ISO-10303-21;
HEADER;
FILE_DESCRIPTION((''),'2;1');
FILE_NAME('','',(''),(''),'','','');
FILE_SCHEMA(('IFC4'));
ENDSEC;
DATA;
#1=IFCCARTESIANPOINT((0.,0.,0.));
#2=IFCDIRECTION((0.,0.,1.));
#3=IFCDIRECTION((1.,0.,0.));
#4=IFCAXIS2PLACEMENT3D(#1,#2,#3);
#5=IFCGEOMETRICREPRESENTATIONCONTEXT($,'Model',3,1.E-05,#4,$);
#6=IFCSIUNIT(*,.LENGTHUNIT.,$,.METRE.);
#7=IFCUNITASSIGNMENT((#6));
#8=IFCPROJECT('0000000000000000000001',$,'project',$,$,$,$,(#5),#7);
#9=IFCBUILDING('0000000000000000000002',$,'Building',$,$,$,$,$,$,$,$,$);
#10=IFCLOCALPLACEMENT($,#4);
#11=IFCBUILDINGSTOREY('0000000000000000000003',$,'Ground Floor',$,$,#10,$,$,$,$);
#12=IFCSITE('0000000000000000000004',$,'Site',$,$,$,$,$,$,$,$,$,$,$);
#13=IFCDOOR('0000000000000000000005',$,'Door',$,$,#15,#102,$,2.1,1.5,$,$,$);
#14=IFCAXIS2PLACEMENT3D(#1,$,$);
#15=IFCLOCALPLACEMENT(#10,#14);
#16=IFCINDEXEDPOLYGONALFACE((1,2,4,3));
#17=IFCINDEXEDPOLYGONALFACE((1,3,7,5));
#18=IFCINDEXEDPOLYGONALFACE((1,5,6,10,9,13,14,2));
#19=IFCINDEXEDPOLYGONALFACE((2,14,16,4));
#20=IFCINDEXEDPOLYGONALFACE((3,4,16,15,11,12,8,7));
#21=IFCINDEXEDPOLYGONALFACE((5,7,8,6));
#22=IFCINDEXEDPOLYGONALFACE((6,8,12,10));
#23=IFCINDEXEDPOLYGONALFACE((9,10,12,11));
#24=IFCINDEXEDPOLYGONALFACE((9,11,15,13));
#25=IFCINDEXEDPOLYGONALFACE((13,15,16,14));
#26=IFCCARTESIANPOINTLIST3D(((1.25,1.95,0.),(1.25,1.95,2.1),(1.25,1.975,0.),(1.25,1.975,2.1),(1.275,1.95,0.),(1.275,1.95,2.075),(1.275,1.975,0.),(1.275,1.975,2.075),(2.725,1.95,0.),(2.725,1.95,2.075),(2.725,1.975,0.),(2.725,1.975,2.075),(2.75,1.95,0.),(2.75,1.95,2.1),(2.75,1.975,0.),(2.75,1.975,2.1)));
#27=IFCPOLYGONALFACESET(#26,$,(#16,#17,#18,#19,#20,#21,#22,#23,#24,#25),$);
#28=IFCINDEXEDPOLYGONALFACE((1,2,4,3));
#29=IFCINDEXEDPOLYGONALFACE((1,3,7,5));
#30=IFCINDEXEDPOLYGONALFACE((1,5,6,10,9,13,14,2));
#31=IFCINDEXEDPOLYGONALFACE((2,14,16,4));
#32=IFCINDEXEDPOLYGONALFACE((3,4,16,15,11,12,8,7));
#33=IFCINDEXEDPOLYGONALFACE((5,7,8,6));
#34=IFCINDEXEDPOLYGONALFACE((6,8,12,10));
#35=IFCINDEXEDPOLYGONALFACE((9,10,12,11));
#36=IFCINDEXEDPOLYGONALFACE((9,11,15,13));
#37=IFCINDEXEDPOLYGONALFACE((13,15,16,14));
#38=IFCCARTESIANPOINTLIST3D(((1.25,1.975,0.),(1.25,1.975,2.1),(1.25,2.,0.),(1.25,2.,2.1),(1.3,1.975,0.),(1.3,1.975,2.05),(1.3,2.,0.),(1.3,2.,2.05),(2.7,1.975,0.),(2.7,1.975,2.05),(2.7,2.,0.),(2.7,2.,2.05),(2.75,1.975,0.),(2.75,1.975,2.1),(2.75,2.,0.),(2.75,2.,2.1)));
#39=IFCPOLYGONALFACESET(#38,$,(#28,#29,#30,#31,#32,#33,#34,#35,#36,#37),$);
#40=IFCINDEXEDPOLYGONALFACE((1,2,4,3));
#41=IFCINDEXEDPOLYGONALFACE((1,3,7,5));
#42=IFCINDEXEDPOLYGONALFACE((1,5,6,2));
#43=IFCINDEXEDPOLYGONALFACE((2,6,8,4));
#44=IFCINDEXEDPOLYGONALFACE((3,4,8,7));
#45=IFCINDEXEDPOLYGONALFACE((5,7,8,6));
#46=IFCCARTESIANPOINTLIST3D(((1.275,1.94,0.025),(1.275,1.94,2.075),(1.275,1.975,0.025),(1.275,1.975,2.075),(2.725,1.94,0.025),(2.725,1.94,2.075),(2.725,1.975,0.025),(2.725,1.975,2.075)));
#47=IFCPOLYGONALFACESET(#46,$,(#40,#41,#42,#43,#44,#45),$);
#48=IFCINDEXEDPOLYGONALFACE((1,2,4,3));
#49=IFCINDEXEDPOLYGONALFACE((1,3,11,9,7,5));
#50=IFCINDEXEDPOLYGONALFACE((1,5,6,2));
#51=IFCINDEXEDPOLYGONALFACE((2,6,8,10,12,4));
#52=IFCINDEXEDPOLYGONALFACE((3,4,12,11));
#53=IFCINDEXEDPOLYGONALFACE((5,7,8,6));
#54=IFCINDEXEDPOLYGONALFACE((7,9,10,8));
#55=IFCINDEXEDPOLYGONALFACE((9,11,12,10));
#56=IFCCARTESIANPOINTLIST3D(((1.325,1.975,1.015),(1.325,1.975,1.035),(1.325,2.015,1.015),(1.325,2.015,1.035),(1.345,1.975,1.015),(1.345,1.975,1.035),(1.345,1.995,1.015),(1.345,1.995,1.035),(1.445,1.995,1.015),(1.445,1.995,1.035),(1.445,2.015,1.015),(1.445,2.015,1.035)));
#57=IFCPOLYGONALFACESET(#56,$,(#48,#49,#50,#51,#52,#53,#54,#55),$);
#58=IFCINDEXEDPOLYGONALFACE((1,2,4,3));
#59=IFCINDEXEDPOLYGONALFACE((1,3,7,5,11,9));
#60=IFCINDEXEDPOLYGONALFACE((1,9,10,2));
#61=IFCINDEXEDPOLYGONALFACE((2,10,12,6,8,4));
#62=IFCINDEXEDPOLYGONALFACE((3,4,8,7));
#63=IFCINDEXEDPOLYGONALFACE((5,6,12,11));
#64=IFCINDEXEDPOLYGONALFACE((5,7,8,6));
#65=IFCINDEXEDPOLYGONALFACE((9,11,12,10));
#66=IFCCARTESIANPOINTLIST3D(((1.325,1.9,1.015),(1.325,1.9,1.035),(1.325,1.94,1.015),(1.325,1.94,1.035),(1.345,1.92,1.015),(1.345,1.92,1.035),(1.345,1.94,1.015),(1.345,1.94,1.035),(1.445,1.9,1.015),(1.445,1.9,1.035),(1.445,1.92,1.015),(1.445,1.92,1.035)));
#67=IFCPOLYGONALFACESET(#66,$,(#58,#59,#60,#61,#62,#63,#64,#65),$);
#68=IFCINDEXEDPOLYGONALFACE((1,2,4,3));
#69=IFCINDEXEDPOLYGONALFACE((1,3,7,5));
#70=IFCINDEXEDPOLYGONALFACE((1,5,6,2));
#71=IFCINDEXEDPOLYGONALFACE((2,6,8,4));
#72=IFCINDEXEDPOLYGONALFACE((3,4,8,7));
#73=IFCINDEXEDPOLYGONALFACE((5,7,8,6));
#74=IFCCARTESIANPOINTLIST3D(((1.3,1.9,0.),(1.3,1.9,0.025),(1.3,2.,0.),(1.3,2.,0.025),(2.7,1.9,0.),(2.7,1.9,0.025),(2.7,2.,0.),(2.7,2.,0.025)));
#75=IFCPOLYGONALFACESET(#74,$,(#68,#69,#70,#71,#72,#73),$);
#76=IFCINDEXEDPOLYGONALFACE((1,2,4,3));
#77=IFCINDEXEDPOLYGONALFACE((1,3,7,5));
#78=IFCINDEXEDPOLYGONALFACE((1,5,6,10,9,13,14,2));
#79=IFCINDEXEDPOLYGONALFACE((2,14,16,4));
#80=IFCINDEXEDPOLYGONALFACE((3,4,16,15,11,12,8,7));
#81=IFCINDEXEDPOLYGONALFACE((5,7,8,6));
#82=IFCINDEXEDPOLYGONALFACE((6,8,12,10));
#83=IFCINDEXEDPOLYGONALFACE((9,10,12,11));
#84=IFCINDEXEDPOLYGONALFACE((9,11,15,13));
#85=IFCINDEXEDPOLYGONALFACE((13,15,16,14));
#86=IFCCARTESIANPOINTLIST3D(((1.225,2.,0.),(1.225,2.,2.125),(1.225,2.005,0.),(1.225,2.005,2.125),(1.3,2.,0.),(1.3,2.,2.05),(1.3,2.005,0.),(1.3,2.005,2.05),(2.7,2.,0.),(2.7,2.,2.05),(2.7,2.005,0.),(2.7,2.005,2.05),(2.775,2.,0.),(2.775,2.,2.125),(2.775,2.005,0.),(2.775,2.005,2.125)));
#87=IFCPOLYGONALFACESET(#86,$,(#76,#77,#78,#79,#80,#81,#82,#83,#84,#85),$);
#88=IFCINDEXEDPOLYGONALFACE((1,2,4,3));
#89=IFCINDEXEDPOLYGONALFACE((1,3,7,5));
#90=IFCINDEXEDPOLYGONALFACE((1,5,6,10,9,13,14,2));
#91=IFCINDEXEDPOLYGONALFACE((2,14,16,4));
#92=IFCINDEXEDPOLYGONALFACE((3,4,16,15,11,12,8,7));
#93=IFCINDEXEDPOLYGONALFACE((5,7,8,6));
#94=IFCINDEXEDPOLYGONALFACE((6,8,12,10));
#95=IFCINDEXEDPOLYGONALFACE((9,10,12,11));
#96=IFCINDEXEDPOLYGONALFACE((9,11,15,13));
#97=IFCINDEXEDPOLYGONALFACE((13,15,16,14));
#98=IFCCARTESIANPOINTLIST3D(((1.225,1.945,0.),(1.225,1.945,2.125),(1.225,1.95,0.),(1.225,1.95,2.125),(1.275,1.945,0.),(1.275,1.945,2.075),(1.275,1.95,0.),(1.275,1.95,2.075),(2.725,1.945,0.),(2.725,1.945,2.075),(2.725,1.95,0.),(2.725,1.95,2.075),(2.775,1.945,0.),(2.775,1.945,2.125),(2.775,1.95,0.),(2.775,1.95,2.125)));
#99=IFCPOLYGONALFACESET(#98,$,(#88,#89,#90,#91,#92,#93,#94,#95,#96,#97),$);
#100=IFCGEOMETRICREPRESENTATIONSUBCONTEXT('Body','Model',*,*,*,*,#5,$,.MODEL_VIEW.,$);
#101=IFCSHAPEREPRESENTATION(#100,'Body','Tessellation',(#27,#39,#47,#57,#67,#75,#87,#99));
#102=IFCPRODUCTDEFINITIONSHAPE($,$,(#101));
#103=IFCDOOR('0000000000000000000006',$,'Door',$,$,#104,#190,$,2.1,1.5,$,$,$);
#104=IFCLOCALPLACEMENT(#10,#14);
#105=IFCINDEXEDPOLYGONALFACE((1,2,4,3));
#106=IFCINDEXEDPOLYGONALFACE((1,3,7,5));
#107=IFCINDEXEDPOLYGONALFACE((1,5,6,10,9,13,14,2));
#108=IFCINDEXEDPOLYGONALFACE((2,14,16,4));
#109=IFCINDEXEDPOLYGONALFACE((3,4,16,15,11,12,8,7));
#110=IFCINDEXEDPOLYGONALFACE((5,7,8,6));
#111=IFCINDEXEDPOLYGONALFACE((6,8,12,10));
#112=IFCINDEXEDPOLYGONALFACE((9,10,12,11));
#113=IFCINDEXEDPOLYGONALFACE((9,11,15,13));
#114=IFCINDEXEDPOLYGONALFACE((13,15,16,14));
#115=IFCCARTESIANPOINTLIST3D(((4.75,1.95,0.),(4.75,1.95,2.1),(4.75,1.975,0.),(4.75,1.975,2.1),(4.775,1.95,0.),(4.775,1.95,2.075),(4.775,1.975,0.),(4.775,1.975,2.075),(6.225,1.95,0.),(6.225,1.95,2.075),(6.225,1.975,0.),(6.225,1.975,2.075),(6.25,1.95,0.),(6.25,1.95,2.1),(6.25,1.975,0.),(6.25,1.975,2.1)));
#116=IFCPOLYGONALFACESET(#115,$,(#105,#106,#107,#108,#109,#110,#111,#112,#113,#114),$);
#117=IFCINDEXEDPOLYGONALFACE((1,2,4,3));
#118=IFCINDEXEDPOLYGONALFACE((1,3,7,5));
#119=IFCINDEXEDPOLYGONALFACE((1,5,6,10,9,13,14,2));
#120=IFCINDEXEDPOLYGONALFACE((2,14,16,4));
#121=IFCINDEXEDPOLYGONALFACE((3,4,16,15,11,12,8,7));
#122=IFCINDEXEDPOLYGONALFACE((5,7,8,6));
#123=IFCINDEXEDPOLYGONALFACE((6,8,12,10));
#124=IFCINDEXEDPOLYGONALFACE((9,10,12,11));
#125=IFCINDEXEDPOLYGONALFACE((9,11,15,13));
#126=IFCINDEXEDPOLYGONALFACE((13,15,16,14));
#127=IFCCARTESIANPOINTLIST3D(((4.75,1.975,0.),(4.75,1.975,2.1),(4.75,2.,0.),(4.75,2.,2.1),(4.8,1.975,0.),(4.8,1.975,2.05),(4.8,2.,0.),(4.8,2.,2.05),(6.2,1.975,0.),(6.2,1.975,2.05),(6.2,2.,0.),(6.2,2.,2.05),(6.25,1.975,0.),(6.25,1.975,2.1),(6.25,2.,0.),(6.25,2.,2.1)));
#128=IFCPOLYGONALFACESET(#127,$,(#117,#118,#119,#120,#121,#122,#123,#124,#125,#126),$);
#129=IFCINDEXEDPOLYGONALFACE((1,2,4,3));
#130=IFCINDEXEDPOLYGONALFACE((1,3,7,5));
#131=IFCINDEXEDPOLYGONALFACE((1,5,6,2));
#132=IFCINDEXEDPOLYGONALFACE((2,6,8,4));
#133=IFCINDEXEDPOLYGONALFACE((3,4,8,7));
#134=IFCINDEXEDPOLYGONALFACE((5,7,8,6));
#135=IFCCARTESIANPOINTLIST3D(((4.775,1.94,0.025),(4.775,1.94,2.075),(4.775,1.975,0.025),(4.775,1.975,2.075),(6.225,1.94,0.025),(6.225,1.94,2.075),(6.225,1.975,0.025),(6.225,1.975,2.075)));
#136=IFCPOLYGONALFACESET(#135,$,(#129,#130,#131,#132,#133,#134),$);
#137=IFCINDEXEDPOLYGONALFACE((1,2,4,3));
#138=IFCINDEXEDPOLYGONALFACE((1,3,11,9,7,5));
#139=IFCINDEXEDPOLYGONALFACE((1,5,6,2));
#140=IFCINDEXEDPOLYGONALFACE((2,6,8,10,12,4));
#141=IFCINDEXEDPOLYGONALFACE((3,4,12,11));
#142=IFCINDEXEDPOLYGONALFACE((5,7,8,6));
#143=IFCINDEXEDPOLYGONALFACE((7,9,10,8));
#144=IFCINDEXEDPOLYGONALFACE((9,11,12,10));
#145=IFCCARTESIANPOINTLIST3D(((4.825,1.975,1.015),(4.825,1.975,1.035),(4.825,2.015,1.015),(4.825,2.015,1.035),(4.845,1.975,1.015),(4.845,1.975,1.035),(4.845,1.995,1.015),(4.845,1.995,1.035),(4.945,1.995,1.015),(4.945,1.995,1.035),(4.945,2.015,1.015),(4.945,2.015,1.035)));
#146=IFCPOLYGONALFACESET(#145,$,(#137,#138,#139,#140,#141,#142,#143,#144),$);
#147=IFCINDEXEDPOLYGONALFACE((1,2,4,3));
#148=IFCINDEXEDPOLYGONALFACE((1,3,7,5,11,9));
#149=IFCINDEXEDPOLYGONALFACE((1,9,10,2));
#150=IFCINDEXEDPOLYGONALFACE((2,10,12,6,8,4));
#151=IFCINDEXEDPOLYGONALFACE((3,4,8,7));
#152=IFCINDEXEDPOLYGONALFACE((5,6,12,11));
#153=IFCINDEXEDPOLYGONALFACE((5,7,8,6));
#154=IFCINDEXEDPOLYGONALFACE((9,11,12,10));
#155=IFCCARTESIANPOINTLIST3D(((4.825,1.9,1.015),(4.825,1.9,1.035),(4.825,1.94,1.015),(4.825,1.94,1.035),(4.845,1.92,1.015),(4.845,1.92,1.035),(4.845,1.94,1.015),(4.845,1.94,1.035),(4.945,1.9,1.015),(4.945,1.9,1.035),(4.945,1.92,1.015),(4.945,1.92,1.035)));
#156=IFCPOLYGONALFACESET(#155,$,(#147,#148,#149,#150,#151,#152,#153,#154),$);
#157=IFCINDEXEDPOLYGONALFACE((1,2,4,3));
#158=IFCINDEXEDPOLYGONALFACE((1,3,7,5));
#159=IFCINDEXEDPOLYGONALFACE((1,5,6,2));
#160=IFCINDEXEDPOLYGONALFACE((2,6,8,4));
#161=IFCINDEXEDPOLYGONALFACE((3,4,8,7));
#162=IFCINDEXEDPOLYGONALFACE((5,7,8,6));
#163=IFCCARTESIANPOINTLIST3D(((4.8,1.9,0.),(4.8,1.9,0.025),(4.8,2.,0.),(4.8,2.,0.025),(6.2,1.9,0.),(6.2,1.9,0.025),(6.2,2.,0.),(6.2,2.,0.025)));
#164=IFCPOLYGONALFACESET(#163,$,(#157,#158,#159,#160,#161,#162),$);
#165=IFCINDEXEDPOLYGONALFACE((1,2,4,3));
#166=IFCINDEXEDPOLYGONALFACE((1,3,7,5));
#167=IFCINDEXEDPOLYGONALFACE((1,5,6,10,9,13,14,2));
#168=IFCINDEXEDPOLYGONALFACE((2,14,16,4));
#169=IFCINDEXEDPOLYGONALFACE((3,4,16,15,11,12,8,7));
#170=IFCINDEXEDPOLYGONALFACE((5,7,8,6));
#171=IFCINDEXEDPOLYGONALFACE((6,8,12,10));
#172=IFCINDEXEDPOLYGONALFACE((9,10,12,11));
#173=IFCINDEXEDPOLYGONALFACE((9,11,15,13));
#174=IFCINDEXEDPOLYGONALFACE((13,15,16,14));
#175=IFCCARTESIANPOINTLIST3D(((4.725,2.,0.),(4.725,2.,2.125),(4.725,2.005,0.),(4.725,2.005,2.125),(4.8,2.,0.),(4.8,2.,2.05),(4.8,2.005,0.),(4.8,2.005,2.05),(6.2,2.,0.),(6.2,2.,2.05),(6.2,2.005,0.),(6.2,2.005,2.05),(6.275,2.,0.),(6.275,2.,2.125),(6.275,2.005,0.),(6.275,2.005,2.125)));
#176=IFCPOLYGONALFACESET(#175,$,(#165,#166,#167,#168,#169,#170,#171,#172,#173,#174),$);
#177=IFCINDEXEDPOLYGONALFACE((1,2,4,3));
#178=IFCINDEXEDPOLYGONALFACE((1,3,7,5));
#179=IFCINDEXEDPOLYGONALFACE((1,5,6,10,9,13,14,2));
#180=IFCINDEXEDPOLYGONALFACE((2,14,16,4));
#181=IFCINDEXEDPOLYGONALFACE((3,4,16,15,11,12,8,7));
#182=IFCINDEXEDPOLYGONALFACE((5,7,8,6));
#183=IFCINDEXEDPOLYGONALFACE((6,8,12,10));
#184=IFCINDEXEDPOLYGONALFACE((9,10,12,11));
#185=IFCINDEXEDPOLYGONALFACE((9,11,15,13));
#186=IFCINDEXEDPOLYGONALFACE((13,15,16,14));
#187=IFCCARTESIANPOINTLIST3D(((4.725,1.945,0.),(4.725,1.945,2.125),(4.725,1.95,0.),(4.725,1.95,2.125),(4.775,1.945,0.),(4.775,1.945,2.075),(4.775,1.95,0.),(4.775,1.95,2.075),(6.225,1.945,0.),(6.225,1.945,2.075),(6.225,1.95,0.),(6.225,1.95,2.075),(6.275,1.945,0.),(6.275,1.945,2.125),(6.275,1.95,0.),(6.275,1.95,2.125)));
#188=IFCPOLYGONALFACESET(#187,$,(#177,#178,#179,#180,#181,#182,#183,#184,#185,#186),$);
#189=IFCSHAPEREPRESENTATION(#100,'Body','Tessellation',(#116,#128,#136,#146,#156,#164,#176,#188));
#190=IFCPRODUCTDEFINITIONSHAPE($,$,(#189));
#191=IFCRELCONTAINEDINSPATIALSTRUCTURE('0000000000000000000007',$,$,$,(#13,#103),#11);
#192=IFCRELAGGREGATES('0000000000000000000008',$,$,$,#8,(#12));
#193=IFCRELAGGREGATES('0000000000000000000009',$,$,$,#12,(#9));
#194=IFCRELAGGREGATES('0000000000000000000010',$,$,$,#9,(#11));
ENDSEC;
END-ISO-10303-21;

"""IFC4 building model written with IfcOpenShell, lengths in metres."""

from ifc_helpers import new_model, si_unit, frame, origin_with_axes, place, context, subcontext, project, spatial, line, indexed_curve, outline, extrude, element, save


model = new_model("IFC4")

# Units and contexts
model_context = context("Model", 3, precision=1e-05, world=origin_with_axes())
body_context = subcontext(model_context, "Body", "Model", "MODEL_VIEW")
ifc_project = project(units=[si_unit("LENGTHUNIT", "METRE")], contexts=[model_context])

# Site, building, storey
site = spatial("IfcSite", under=ifc_project, Name="Site")
building = spatial("IfcBuilding", under=site, Name="Building")
storey_placement = place(None, origin_with_axes())
storey = spatial("IfcBuildingStorey", under=building, at=storey_placement, Name="Ground Floor")

# Doors
door_1_placement = place(storey_placement, frame((2.75, 2.0, 0.0), z_axis=(0.0, 0.0, 1.0), x_axis=(-1.0, 0.0, 0.0)))
element("IfcDoor", 1, at=door_1_placement, inside=storey, Name="Door", OverallHeight=2.1, OverallWidth=1.5, context=body_context, shape_type="SweptSolid", body=[
    extrude(outline(indexed_curve([(0.0, 0.0), (0.0, 2.1), (1.5, 2.1), (1.5, 0.0), (1.475, 0.0), (1.475, 2.075), (0.025, 2.075), (0.025, 0.0)], segments=[line(1, 2, 3, 4, 5, 6, 7, 8, 1)])), frame((0.0, 0.025, 0.0), z_axis=(0.0, -1.0, 0.0), x_axis=(1.0, 0.0, 0.0)), (0.0, 0.0, -1.0), 0.025),
    extrude(outline(indexed_curve([(0.0, 0.0), (0.0, 2.1), (1.5, 2.1), (1.5, 0.0), (1.45, 0.0), (1.45, 2.05), (0.05, 2.05), (0.05, 0.0)], segments=[line(1, 2, 3, 4, 5, 6, 7, 8, 1)])), frame((0.0, 0.0, 0.0), z_axis=(0.0, -1.0, 0.0), x_axis=(1.0, 0.0, 0.0)), (0.0, 0.0, -1.0), 0.025),
    extrude(outline(indexed_curve([(0.0, 0.0), (1.45, 0.0), (1.45, 0.035), (0.0, 0.035)], segments=[line(1, 2, 3, 4, 1)])), frame((0.025, 0.025, 0.025), z_axis=(0.0, 0.0, 1.0), x_axis=(1.0, 0.0, 0.0)), (0.0, 0.0, 1.0), 2.05),
    extrude(outline(indexed_curve([(0.0, 0.0), (0.0, -0.04), (-0.12, -0.04), (-0.12, -0.02), (-0.02, -0.02), (-0.02, 0.0)], segments=[line(1, 2, 3, 4, 5, 6, 1)])), frame((1.425, 0.025, 1.015), z_axis=(0.0, 0.0, 1.0), x_axis=(1.0, 0.0, 0.0)), (0.0, 0.0, 1.0), 0.02),
    extrude(outline(indexed_curve([(0.0, 0.0), (0.0, 0.04), (-0.12, 0.04), (-0.12, 0.02), (-0.02, 0.02), (-0.02, 0.0)], segments=[line(1, 2, 3, 4, 5, 6, 1)])), frame((1.425, 0.06, 1.015), z_axis=(0.0, 0.0, 1.0), x_axis=(1.0, 0.0, 0.0)), (0.0, 0.0, 1.0), 0.02),
    extrude(outline(indexed_curve([(0.0, 0.0), (1.4, 0.0), (1.4, 0.1), (0.0, 0.1)], segments=[line(1, 2, 3, 4, 1)])), frame((0.05, 0.0, 0.0), z_axis=(0.0, 0.0, 1.0), x_axis=(1.0, 0.0, 0.0)), (0.0, 0.0, 1.0), 0.025),
    extrude(outline(indexed_curve([(0.0, 0.0), (0.0, 2.125), (1.55, 2.125), (1.55, 0.0), (1.475, 0.0), (1.475, 2.05), (0.075, 2.05), (0.075, 0.0)], segments=[line(1, 2, 3, 4, 5, 6, 7, 8, 1)])), frame((-0.025, -0.005, 0.0), z_axis=(0.0, -1.0, 0.0), x_axis=(1.0, 0.0, 0.0)), (0.0, 0.0, -1.0), 0.005),
    extrude(outline(indexed_curve([(0.0, 0.0), (0.0, 2.125), (1.55, 2.125), (1.55, 0.0), (1.5, 0.0), (1.5, 2.075), (0.05, 2.075), (0.05, 0.0)], segments=[line(1, 2, 3, 4, 5, 6, 7, 8, 1)])), frame((-0.025, 0.05, 0.0), z_axis=(0.0, -1.0, 0.0), x_axis=(1.0, 0.0, 0.0)), (0.0, 0.0, -1.0), 0.005),
])
door_2_placement = place(storey_placement, frame((6.25, 2.0, 0.0), z_axis=(0.0, 0.0, 1.0), x_axis=(-1.0, 0.0, 0.0)))
element("IfcDoor", 2, at=door_2_placement, inside=storey, Name="Door", OverallHeight=2.1, OverallWidth=1.5, context=body_context, shape_type="SweptSolid", body=[
    extrude(outline(indexed_curve([(0.0, 0.0), (0.0, 2.1), (1.5, 2.1), (1.5, 0.0), (1.475, 0.0), (1.475, 2.075), (0.025, 2.075), (0.025, 0.0)], segments=[line(1, 2, 3, 4, 5, 6, 7, 8, 1)])), frame((0.0, 0.025, 0.0), z_axis=(0.0, -1.0, 0.0), x_axis=(1.0, 0.0, 0.0)), (0.0, 0.0, -1.0), 0.025),
    extrude(outline(indexed_curve([(0.0, 0.0), (0.0, 2.1), (1.5, 2.1), (1.5, 0.0), (1.45, 0.0), (1.45, 2.05), (0.05, 2.05), (0.05, 0.0)], segments=[line(1, 2, 3, 4, 5, 6, 7, 8, 1)])), frame((0.0, 0.0, 0.0), z_axis=(0.0, -1.0, 0.0), x_axis=(1.0, 0.0, 0.0)), (0.0, 0.0, -1.0), 0.025),
    extrude(outline(indexed_curve([(0.0, 0.0), (1.45, 0.0), (1.45, 0.035), (0.0, 0.035)], segments=[line(1, 2, 3, 4, 1)])), frame((0.025, 0.025, 0.025), z_axis=(0.0, 0.0, 1.0), x_axis=(1.0, 0.0, 0.0)), (0.0, 0.0, 1.0), 2.05),
    extrude(outline(indexed_curve([(0.0, 0.0), (0.0, -0.04), (-0.12, -0.04), (-0.12, -0.02), (-0.02, -0.02), (-0.02, 0.0)], segments=[line(1, 2, 3, 4, 5, 6, 1)])), frame((1.425, 0.025, 1.015), z_axis=(0.0, 0.0, 1.0), x_axis=(1.0, 0.0, 0.0)), (0.0, 0.0, 1.0), 0.02),
    extrude(outline(indexed_curve([(0.0, 0.0), (0.0, 0.04), (-0.12, 0.04), (-0.12, 0.02), (-0.02, 0.02), (-0.02, 0.0)], segments=[line(1, 2, 3, 4, 5, 6, 1)])), frame((1.425, 0.06, 1.015), z_axis=(0.0, 0.0, 1.0), x_axis=(1.0, 0.0, 0.0)), (0.0, 0.0, 1.0), 0.02),
    extrude(outline(indexed_curve([(0.0, 0.0), (1.4, 0.0), (1.4, 0.1), (0.0, 0.1)], segments=[line(1, 2, 3, 4, 1)])), frame((0.05, 0.0, 0.0), z_axis=(0.0, 0.0, 1.0), x_axis=(1.0, 0.0, 0.0)), (0.0, 0.0, 1.0), 0.025),
    extrude(outline(indexed_curve([(0.0, 0.0), (0.0, 2.125), (1.55, 2.125), (1.55, 0.0), (1.475, 0.0), (1.475, 2.05), (0.075, 2.05), (0.075, 0.0)], segments=[line(1, 2, 3, 4, 5, 6, 7, 8, 1)])), frame((-0.025, -0.005, 0.0), z_axis=(0.0, -1.0, 0.0), x_axis=(1.0, 0.0, 0.0)), (0.0, 0.0, -1.0), 0.005),
    extrude(outline(indexed_curve([(0.0, 0.0), (0.0, 2.125), (1.55, 2.125), (1.55, 0.0), (1.5, 0.0), (1.5, 2.075), (0.05, 2.075), (0.05, 0.0)], segments=[line(1, 2, 3, 4, 5, 6, 7, 8, 1)])), frame((-0.025, 0.05, 0.0), z_axis=(0.0, -1.0, 0.0), x_axis=(1.0, 0.0, 0.0)), (0.0, 0.0, -1.0), 0.005),
])

save(model, "model.ifc")
